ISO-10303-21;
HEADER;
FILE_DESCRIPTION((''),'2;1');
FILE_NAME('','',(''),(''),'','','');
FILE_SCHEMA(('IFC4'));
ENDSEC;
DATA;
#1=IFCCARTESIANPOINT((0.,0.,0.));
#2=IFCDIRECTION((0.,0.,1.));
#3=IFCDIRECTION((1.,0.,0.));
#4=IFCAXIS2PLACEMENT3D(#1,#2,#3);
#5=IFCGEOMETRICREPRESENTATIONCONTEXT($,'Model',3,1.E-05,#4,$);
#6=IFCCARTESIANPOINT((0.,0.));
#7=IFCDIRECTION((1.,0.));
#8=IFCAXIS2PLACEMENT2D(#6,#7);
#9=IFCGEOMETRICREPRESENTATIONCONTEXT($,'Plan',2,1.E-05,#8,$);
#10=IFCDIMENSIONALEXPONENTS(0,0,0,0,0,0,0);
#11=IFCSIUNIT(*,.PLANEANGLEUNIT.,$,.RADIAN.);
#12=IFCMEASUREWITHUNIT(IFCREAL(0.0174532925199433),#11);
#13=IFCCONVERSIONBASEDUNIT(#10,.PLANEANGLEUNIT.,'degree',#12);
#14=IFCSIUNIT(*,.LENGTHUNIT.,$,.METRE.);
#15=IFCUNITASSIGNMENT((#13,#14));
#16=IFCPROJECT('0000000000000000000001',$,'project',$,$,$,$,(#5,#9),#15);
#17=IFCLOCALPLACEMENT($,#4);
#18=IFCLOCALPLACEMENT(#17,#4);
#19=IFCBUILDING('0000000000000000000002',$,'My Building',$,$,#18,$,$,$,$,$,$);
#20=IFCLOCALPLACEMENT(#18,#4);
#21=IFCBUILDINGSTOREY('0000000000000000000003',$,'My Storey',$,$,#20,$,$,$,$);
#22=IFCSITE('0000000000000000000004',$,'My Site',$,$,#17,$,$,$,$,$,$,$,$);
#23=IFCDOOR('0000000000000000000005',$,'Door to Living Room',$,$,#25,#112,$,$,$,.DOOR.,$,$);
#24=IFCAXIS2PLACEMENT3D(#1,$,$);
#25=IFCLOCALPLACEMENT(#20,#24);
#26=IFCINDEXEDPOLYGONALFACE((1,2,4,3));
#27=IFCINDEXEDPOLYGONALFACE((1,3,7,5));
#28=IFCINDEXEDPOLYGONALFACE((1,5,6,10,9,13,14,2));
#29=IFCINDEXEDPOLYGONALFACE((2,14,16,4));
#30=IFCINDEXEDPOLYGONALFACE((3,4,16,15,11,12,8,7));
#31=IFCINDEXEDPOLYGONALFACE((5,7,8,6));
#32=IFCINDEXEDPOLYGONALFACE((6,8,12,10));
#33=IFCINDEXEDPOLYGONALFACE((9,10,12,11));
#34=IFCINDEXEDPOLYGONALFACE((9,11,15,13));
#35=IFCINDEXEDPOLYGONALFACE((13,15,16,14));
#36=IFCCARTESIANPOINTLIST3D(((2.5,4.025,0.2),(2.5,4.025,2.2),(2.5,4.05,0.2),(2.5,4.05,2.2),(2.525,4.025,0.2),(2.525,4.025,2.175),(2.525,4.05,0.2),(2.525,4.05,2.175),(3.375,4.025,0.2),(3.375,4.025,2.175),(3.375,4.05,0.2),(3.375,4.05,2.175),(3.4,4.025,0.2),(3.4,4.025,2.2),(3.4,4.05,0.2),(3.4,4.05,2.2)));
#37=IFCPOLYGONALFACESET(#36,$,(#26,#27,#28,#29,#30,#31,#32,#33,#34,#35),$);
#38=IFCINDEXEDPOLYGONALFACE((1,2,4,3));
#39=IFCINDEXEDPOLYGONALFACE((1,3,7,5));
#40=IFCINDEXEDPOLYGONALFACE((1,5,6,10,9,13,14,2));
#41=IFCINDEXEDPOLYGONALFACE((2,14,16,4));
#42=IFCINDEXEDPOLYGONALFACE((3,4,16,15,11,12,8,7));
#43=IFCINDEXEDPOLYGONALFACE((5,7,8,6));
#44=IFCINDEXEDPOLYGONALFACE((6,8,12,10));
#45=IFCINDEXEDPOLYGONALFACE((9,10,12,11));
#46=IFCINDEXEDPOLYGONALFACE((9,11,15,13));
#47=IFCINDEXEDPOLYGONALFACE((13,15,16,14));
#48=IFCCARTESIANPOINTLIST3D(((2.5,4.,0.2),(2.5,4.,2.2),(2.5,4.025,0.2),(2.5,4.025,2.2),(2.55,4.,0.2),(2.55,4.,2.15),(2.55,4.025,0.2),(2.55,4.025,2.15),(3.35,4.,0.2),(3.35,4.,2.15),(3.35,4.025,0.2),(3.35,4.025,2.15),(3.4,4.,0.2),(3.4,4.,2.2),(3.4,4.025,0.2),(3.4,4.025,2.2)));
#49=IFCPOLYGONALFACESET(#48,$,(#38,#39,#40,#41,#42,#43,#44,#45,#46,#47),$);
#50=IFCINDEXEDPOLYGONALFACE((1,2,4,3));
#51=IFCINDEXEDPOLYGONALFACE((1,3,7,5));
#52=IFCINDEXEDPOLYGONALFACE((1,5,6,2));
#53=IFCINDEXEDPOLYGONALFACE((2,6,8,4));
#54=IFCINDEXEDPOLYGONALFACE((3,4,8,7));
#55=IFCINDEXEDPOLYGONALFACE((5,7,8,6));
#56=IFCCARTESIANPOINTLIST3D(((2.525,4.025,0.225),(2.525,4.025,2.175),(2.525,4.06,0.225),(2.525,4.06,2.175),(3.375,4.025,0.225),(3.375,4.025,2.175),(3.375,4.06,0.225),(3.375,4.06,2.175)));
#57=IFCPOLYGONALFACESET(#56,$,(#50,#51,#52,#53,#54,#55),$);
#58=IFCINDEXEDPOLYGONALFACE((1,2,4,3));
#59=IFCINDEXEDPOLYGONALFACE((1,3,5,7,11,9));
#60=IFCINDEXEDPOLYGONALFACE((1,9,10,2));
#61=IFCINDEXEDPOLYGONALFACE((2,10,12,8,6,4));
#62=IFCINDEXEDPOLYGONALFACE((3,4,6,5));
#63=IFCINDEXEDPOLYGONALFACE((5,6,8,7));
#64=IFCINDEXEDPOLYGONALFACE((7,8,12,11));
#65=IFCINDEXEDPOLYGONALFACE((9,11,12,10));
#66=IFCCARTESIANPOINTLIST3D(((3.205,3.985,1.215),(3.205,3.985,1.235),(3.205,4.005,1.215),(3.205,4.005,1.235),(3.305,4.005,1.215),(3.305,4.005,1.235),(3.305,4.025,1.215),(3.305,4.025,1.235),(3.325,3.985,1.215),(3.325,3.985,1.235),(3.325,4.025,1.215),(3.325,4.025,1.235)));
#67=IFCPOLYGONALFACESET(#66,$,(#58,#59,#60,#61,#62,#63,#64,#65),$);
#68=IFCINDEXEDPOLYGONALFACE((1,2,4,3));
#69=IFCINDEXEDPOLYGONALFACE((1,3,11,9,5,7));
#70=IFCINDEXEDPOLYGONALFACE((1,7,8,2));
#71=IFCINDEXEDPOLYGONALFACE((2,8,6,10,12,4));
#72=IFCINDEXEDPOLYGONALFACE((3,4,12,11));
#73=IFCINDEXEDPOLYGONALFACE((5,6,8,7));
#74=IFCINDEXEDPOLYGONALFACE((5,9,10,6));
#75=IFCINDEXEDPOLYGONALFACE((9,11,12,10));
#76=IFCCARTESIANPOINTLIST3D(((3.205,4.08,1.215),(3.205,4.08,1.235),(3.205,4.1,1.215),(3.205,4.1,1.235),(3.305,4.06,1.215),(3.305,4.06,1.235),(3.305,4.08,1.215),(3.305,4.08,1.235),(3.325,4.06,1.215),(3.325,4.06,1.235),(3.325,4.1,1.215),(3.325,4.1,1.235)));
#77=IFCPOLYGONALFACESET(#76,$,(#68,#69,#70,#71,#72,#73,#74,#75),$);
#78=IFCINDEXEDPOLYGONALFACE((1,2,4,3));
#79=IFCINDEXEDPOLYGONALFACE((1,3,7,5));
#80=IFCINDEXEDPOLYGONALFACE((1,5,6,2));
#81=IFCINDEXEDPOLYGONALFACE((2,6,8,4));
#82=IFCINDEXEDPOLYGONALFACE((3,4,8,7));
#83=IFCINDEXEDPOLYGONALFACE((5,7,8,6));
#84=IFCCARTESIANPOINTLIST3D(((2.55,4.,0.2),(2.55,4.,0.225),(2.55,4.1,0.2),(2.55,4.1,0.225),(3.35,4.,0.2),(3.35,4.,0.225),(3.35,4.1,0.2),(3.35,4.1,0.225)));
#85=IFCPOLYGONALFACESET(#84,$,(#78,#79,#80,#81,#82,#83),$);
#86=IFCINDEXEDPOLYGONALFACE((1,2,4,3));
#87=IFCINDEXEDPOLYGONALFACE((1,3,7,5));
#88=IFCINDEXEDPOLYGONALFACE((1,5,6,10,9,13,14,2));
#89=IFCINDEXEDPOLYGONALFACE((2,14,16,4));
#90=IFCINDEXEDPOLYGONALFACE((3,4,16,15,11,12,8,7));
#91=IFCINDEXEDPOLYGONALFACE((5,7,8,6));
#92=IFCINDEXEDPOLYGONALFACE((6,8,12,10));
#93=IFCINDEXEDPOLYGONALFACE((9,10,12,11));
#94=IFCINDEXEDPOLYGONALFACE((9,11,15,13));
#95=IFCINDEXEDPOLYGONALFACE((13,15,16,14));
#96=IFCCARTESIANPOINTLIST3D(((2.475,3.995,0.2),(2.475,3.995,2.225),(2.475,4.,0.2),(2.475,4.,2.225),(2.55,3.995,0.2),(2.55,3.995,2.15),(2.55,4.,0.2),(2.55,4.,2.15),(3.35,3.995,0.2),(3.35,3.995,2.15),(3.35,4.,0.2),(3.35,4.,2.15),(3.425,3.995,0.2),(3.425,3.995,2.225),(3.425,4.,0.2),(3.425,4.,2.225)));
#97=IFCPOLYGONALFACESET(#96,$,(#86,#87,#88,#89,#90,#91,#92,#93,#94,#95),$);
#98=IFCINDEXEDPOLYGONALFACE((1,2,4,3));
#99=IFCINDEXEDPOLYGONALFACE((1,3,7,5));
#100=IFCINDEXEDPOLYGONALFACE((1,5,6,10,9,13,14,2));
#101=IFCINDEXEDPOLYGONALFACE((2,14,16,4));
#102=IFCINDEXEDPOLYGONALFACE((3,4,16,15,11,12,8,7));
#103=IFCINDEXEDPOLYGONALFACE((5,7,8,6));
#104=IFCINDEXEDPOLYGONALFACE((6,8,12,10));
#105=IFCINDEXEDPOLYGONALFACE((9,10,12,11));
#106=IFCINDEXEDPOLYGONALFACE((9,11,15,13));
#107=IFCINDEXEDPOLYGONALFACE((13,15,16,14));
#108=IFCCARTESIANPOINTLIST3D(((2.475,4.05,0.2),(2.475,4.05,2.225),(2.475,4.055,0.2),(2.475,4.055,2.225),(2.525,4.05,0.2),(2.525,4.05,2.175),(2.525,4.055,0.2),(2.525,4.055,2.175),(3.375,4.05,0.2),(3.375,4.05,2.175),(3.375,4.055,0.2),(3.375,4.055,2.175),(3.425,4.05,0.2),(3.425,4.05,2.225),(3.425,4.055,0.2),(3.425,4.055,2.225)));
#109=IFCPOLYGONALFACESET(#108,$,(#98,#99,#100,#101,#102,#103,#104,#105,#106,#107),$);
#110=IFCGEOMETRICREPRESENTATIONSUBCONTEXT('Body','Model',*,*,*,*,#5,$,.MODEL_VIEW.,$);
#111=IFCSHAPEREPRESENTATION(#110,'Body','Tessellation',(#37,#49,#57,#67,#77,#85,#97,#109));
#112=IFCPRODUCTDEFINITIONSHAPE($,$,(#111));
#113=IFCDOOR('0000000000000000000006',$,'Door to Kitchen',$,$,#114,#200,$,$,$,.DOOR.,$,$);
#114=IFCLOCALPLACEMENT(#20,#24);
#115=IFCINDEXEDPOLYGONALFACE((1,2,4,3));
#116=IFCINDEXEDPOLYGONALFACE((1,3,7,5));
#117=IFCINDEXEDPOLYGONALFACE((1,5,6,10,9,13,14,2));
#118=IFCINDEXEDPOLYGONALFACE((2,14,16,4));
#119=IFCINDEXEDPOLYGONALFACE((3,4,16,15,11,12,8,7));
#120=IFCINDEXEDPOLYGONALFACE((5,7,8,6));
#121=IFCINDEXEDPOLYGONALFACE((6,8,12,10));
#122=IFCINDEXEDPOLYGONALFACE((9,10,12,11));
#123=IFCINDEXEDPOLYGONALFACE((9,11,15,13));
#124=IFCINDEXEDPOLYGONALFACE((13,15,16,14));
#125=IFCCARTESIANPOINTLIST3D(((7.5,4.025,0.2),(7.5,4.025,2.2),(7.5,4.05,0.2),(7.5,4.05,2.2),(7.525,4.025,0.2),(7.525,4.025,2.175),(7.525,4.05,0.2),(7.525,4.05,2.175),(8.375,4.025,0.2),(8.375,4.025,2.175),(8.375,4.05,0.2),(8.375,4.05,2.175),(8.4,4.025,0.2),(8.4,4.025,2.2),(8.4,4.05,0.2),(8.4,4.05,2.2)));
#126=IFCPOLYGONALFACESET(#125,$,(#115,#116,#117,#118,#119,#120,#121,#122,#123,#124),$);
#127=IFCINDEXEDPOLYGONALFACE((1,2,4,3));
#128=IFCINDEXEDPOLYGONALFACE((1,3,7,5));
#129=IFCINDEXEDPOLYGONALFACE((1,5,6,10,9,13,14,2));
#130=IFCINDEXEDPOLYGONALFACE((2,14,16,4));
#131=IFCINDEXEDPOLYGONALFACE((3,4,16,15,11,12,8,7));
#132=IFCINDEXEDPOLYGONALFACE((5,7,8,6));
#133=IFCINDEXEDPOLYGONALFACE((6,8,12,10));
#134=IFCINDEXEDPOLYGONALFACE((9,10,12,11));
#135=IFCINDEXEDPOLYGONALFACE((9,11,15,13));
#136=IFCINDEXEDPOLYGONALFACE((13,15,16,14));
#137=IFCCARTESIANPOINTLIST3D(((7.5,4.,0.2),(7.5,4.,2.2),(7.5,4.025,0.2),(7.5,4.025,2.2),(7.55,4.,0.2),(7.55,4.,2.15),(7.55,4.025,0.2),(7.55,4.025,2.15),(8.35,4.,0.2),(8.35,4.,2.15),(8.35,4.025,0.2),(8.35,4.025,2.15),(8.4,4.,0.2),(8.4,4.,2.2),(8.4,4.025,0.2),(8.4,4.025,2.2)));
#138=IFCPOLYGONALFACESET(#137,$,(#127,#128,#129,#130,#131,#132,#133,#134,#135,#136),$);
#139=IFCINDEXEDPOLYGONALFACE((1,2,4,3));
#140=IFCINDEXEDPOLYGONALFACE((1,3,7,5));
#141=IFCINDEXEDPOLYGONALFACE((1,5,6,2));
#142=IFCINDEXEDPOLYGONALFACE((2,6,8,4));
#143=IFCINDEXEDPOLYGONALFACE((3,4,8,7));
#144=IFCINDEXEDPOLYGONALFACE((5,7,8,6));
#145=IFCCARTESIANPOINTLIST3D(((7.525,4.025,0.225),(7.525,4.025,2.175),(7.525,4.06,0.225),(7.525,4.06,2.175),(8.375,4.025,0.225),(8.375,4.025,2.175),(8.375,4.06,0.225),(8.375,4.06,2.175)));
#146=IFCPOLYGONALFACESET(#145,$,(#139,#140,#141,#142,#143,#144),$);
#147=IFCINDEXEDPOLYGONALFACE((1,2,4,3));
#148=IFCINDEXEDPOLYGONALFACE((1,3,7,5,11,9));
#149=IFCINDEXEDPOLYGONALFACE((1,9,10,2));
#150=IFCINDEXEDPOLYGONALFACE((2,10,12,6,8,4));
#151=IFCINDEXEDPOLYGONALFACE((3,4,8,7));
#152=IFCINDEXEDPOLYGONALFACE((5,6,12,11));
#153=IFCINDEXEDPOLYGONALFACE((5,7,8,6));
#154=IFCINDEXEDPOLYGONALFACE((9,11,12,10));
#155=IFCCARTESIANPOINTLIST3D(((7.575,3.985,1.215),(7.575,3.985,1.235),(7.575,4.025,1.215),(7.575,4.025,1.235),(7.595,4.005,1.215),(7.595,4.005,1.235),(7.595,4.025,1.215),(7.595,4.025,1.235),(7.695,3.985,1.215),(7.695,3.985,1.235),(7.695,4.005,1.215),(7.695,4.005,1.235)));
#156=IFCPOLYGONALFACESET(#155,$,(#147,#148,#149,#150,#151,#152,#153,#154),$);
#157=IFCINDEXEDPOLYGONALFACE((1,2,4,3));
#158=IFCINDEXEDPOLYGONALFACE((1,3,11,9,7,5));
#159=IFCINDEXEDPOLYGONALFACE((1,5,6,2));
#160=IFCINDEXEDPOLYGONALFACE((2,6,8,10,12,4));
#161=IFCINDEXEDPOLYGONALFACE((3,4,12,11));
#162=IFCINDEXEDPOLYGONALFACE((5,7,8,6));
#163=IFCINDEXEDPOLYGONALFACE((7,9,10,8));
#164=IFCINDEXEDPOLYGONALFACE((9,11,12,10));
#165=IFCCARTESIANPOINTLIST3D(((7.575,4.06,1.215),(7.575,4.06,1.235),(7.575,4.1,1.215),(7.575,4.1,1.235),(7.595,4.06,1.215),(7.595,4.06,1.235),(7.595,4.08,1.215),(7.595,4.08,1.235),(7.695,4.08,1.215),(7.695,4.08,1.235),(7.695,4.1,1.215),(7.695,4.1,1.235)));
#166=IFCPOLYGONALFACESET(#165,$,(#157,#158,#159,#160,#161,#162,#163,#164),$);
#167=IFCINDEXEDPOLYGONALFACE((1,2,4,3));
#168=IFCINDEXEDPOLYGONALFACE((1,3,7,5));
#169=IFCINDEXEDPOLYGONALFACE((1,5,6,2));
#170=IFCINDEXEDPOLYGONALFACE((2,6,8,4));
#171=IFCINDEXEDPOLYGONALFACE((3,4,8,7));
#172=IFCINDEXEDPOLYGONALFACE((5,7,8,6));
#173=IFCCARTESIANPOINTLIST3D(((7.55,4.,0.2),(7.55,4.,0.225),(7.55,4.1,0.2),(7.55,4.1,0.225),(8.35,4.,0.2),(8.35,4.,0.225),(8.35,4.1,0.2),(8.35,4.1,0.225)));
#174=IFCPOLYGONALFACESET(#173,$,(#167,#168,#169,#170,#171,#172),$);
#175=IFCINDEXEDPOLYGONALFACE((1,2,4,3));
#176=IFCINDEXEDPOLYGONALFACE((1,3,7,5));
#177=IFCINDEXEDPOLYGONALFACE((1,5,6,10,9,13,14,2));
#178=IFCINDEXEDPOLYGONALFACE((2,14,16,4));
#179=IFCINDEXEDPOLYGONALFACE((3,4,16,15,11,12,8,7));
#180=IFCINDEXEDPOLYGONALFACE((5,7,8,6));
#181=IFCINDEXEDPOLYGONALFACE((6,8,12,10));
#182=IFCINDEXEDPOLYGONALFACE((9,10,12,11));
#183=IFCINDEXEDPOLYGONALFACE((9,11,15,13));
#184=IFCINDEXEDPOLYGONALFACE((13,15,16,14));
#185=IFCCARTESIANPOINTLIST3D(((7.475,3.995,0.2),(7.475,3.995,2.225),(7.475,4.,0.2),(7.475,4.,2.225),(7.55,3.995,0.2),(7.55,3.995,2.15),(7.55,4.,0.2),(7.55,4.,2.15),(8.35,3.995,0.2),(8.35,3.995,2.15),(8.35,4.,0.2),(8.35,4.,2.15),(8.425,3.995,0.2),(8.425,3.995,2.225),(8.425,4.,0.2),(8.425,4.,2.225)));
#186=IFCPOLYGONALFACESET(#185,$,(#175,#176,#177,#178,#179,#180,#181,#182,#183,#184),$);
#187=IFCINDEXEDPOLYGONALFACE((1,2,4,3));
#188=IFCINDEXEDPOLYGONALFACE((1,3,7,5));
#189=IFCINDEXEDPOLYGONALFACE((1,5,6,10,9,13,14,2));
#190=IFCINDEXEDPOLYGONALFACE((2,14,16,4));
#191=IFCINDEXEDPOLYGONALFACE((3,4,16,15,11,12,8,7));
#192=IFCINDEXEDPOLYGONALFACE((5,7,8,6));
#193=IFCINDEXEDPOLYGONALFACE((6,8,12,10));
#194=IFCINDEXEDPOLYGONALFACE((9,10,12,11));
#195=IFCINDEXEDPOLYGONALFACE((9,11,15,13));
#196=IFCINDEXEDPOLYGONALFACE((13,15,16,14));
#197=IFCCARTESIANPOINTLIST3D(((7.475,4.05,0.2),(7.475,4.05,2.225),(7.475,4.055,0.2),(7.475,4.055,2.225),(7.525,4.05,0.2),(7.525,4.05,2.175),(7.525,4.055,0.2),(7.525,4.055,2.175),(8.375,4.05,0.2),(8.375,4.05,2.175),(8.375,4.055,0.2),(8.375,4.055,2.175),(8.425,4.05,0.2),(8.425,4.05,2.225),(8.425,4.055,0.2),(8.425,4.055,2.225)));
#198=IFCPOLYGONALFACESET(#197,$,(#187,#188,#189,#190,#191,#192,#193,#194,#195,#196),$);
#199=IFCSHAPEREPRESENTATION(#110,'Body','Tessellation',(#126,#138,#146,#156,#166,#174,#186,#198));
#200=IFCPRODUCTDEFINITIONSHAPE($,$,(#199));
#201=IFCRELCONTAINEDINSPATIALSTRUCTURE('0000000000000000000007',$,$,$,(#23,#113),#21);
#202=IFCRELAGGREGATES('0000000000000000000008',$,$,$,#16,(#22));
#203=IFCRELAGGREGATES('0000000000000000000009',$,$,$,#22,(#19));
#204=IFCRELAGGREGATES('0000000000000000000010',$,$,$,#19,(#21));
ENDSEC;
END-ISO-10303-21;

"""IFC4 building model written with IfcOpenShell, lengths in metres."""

from ifc_helpers import new_model, entity, si_unit, converted_unit, frame, origin_with_axes, origin_2d_with_axis, place, context, subcontext, project, spatial, line, indexed_curve, outline, extrude, element, save


model = new_model("IFC4")

# Units and contexts
model_context = context("Model", 3, precision=1e-05, world=origin_with_axes())
plan_context = context("Plan", 2, precision=1e-05, world=origin_2d_with_axis())
body_context = subcontext(model_context, "Body", "Model", "MODEL_VIEW")
ifc_project = project(units=[converted_unit("PLANEANGLEUNIT", "degree", entity("IfcReal", 0.0174532925199433), si_unit("PLANEANGLEUNIT", "RADIAN"), dimensions=[0, 0, 0, 0, 0, 0, 0]), si_unit("LENGTHUNIT", "METRE")], contexts=[model_context, plan_context])

# Site, building, storey
site_placement = place(None, origin_with_axes())
site = spatial("IfcSite", under=ifc_project, at=site_placement, Name="My Site")
building_placement = place(site_placement, origin_with_axes())
building = spatial("IfcBuilding", under=site, at=building_placement, Name="My Building")
storey_placement = place(building_placement, origin_with_axes())
storey = spatial("IfcBuildingStorey", under=building, at=storey_placement, Name="My Storey")

# Doors
door_1_placement = place(storey_placement, frame((2.5, 4.0, 0.2), z_axis=(0.0, 0.0, 1.0), x_axis=(1.0, 0.0, 0.0)))
element("IfcDoor", 1, at=door_1_placement, inside=storey, Name="Door to Living Room", PredefinedType="DOOR", context=body_context, shape_type="SweptSolid", body=[
    extrude(outline(indexed_curve([(0.0, 0.0), (0.0, 2.0), (0.9, 2.0), (0.9, 0.0), (0.875, 0.0), (0.875, 1.975), (0.025, 1.975), (0.025, 0.0)], segments=[line(1, 2, 3, 4, 5, 6, 7, 8, 1)])), frame((0.0, 0.025, 0.0), z_axis=(0.0, -1.0, 0.0), x_axis=(1.0, 0.0, 0.0)), (0.0, 0.0, -1.0), 0.025),
    extrude(outline(indexed_curve([(0.0, 0.0), (0.0, 2.0), (0.9, 2.0), (0.9, 0.0), (0.85, 0.0), (0.85, 1.95), (0.05, 1.95), (0.05, 0.0)], segments=[line(1, 2, 3, 4, 5, 6, 7, 8, 1)])), frame((0.0, 0.0, 0.0), z_axis=(0.0, -1.0, 0.0), x_axis=(1.0, 0.0, 0.0)), (0.0, 0.0, -1.0), 0.025),
    extrude(outline(indexed_curve([(0.0, 0.0), (0.85, 0.0), (0.85, 0.035), (0.0, 0.035)], segments=[line(1, 2, 3, 4, 1)])), frame((0.025, 0.025, 0.025), z_axis=(0.0, 0.0, 1.0), x_axis=(1.0, 0.0, 0.0)), (0.0, 0.0, 1.0), 1.95),
    extrude(outline(indexed_curve([(0.0, 0.0), (0.0, -0.04), (-0.12, -0.04), (-0.12, -0.02), (-0.02, -0.02), (-0.02, 0.0)], segments=[line(1, 2, 3, 4, 5, 6, 1)])), frame((0.825, 0.025, 1.015), z_axis=(0.0, 0.0, 1.0), x_axis=(1.0, 0.0, 0.0)), (0.0, 0.0, 1.0), 0.02),
    extrude(outline(indexed_curve([(0.0, 0.0), (0.0, 0.04), (-0.12, 0.04), (-0.12, 0.02), (-0.02, 0.02), (-0.02, 0.0)], segments=[line(1, 2, 3, 4, 5, 6, 1)])), frame((0.825, 0.06, 1.015), z_axis=(0.0, 0.0, 1.0), x_axis=(1.0, 0.0, 0.0)), (0.0, 0.0, 1.0), 0.02),
    extrude(outline(indexed_curve([(0.0, 0.0), (0.8, 0.0), (0.8, 0.1), (0.0, 0.1)], segments=[line(1, 2, 3, 4, 1)])), frame((0.05, 0.0, 0.0), z_axis=(0.0, 0.0, 1.0), x_axis=(1.0, 0.0, 0.0)), (0.0, 0.0, 1.0), 0.025),
    extrude(outline(indexed_curve([(0.0, 0.0), (0.0, 2.025), (0.95, 2.025), (0.95, 0.0), (0.875, 0.0), (0.875, 1.95), (0.075, 1.95), (0.075, 0.0)], segments=[line(1, 2, 3, 4, 5, 6, 7, 8, 1)])), frame((-0.025, -0.005, 0.0), z_axis=(0.0, -1.0, 0.0), x_axis=(1.0, 0.0, 0.0)), (0.0, 0.0, -1.0), 0.005),
    extrude(outline(indexed_curve([(0.0, 0.0), (0.0, 2.025), (0.95, 2.025), (0.95, 0.0), (0.9, 0.0), (0.9, 1.975), (0.05, 1.975), (0.05, 0.0)], segments=[line(1, 2, 3, 4, 5, 6, 7, 8, 1)])), frame((-0.025, 0.05, 0.0), z_axis=(0.0, -1.0, 0.0), x_axis=(1.0, 0.0, 0.0)), (0.0, 0.0, -1.0), 0.005),
])
door_2_placement = place(storey_placement, frame((7.5, 4.0, 0.2), z_axis=(0.0, 0.0, 1.0), x_axis=(1.0, 0.0, 0.0)))
element("IfcDoor", 2, at=door_2_placement, inside=storey, Name="Door to Kitchen", PredefinedType="DOOR", context=body_context, shape_type="SweptSolid", body=[
    extrude(outline(indexed_curve([(0.0, 0.0), (0.0, 2.0), (0.9, 2.0), (0.9, 0.0), (0.875, 0.0), (0.875, 1.975), (0.025, 1.975), (0.025, 0.0)], segments=[line(1, 2, 3, 4, 5, 6, 7, 8, 1)])), frame((0.0, 0.025, 0.0), z_axis=(0.0, -1.0, 0.0), x_axis=(1.0, 0.0, 0.0)), (0.0, 0.0, -1.0), 0.025),
    extrude(outline(indexed_curve([(0.0, 0.0), (0.0, 2.0), (0.9, 2.0), (0.9, 0.0), (0.85, 0.0), (0.85, 1.95), (0.05, 1.95), (0.05, 0.0)], segments=[line(1, 2, 3, 4, 5, 6, 7, 8, 1)])), frame((0.0, 0.0, 0.0), z_axis=(0.0, -1.0, 0.0), x_axis=(1.0, 0.0, 0.0)), (0.0, 0.0, -1.0), 0.025),
    extrude(outline(indexed_curve([(0.0, 0.0), (0.85, 0.0), (0.85, 0.035), (0.0, 0.035)], segments=[line(1, 2, 3, 4, 1)])), frame((0.025, 0.025, 0.025), z_axis=(0.0, 0.0, 1.0), x_axis=(1.0, 0.0, 0.0)), (0.0, 0.0, 1.0), 1.95),
    extrude(outline(indexed_curve([(0.0, 0.0), (0.0, -0.04), (0.12, -0.04), (0.12, -0.02), (0.02, -0.02), (0.02, 0.0)], segments=[line(1, 2, 3, 4, 5, 6, 1)])), frame((0.075, 0.025, 1.015), z_axis=(0.0, 0.0, 1.0), x_axis=(1.0, 0.0, 0.0)), (0.0, 0.0, 1.0), 0.02),
    extrude(outline(indexed_curve([(0.0, 0.0), (0.0, 0.04), (0.12, 0.04), (0.12, 0.02), (0.02, 0.02), (0.02, 0.0)], segments=[line(1, 2, 3, 4, 5, 6, 1)])), frame((0.075, 0.06, 1.015), z_axis=(0.0, 0.0, 1.0), x_axis=(1.0, 0.0, 0.0)), (0.0, 0.0, 1.0), 0.02),
    extrude(outline(indexed_curve([(0.0, 0.0), (0.8, 0.0), (0.8, 0.1), (0.0, 0.1)], segments=[line(1, 2, 3, 4, 1)])), frame((0.05, 0.0, 0.0), z_axis=(0.0, 0.0, 1.0), x_axis=(1.0, 0.0, 0.0)), (0.0, 0.0, 1.0), 0.025),
    extrude(outline(indexed_curve([(0.0, 0.0), (0.0, 2.025), (0.95, 2.025), (0.95, 0.0), (0.875, 0.0), (0.875, 1.95), (0.075, 1.95), (0.075, 0.0)], segments=[line(1, 2, 3, 4, 5, 6, 7, 8, 1)])), frame((-0.025, -0.005, 0.0), z_axis=(0.0, -1.0, 0.0), x_axis=(1.0, 0.0, 0.0)), (0.0, 0.0, -1.0), 0.005),
    extrude(outline(indexed_curve([(0.0, 0.0), (0.0, 2.025), (0.95, 2.025), (0.95, 0.0), (0.9, 0.0), (0.9, 1.975), (0.05, 1.975), (0.05, 0.0)], segments=[line(1, 2, 3, 4, 5, 6, 7, 8, 1)])), frame((-0.025, 0.05, 0.0), z_axis=(0.0, -1.0, 0.0), x_axis=(1.0, 0.0, 0.0)), (0.0, 0.0, -1.0), 0.005),
])

save(model, "model.ifc")
